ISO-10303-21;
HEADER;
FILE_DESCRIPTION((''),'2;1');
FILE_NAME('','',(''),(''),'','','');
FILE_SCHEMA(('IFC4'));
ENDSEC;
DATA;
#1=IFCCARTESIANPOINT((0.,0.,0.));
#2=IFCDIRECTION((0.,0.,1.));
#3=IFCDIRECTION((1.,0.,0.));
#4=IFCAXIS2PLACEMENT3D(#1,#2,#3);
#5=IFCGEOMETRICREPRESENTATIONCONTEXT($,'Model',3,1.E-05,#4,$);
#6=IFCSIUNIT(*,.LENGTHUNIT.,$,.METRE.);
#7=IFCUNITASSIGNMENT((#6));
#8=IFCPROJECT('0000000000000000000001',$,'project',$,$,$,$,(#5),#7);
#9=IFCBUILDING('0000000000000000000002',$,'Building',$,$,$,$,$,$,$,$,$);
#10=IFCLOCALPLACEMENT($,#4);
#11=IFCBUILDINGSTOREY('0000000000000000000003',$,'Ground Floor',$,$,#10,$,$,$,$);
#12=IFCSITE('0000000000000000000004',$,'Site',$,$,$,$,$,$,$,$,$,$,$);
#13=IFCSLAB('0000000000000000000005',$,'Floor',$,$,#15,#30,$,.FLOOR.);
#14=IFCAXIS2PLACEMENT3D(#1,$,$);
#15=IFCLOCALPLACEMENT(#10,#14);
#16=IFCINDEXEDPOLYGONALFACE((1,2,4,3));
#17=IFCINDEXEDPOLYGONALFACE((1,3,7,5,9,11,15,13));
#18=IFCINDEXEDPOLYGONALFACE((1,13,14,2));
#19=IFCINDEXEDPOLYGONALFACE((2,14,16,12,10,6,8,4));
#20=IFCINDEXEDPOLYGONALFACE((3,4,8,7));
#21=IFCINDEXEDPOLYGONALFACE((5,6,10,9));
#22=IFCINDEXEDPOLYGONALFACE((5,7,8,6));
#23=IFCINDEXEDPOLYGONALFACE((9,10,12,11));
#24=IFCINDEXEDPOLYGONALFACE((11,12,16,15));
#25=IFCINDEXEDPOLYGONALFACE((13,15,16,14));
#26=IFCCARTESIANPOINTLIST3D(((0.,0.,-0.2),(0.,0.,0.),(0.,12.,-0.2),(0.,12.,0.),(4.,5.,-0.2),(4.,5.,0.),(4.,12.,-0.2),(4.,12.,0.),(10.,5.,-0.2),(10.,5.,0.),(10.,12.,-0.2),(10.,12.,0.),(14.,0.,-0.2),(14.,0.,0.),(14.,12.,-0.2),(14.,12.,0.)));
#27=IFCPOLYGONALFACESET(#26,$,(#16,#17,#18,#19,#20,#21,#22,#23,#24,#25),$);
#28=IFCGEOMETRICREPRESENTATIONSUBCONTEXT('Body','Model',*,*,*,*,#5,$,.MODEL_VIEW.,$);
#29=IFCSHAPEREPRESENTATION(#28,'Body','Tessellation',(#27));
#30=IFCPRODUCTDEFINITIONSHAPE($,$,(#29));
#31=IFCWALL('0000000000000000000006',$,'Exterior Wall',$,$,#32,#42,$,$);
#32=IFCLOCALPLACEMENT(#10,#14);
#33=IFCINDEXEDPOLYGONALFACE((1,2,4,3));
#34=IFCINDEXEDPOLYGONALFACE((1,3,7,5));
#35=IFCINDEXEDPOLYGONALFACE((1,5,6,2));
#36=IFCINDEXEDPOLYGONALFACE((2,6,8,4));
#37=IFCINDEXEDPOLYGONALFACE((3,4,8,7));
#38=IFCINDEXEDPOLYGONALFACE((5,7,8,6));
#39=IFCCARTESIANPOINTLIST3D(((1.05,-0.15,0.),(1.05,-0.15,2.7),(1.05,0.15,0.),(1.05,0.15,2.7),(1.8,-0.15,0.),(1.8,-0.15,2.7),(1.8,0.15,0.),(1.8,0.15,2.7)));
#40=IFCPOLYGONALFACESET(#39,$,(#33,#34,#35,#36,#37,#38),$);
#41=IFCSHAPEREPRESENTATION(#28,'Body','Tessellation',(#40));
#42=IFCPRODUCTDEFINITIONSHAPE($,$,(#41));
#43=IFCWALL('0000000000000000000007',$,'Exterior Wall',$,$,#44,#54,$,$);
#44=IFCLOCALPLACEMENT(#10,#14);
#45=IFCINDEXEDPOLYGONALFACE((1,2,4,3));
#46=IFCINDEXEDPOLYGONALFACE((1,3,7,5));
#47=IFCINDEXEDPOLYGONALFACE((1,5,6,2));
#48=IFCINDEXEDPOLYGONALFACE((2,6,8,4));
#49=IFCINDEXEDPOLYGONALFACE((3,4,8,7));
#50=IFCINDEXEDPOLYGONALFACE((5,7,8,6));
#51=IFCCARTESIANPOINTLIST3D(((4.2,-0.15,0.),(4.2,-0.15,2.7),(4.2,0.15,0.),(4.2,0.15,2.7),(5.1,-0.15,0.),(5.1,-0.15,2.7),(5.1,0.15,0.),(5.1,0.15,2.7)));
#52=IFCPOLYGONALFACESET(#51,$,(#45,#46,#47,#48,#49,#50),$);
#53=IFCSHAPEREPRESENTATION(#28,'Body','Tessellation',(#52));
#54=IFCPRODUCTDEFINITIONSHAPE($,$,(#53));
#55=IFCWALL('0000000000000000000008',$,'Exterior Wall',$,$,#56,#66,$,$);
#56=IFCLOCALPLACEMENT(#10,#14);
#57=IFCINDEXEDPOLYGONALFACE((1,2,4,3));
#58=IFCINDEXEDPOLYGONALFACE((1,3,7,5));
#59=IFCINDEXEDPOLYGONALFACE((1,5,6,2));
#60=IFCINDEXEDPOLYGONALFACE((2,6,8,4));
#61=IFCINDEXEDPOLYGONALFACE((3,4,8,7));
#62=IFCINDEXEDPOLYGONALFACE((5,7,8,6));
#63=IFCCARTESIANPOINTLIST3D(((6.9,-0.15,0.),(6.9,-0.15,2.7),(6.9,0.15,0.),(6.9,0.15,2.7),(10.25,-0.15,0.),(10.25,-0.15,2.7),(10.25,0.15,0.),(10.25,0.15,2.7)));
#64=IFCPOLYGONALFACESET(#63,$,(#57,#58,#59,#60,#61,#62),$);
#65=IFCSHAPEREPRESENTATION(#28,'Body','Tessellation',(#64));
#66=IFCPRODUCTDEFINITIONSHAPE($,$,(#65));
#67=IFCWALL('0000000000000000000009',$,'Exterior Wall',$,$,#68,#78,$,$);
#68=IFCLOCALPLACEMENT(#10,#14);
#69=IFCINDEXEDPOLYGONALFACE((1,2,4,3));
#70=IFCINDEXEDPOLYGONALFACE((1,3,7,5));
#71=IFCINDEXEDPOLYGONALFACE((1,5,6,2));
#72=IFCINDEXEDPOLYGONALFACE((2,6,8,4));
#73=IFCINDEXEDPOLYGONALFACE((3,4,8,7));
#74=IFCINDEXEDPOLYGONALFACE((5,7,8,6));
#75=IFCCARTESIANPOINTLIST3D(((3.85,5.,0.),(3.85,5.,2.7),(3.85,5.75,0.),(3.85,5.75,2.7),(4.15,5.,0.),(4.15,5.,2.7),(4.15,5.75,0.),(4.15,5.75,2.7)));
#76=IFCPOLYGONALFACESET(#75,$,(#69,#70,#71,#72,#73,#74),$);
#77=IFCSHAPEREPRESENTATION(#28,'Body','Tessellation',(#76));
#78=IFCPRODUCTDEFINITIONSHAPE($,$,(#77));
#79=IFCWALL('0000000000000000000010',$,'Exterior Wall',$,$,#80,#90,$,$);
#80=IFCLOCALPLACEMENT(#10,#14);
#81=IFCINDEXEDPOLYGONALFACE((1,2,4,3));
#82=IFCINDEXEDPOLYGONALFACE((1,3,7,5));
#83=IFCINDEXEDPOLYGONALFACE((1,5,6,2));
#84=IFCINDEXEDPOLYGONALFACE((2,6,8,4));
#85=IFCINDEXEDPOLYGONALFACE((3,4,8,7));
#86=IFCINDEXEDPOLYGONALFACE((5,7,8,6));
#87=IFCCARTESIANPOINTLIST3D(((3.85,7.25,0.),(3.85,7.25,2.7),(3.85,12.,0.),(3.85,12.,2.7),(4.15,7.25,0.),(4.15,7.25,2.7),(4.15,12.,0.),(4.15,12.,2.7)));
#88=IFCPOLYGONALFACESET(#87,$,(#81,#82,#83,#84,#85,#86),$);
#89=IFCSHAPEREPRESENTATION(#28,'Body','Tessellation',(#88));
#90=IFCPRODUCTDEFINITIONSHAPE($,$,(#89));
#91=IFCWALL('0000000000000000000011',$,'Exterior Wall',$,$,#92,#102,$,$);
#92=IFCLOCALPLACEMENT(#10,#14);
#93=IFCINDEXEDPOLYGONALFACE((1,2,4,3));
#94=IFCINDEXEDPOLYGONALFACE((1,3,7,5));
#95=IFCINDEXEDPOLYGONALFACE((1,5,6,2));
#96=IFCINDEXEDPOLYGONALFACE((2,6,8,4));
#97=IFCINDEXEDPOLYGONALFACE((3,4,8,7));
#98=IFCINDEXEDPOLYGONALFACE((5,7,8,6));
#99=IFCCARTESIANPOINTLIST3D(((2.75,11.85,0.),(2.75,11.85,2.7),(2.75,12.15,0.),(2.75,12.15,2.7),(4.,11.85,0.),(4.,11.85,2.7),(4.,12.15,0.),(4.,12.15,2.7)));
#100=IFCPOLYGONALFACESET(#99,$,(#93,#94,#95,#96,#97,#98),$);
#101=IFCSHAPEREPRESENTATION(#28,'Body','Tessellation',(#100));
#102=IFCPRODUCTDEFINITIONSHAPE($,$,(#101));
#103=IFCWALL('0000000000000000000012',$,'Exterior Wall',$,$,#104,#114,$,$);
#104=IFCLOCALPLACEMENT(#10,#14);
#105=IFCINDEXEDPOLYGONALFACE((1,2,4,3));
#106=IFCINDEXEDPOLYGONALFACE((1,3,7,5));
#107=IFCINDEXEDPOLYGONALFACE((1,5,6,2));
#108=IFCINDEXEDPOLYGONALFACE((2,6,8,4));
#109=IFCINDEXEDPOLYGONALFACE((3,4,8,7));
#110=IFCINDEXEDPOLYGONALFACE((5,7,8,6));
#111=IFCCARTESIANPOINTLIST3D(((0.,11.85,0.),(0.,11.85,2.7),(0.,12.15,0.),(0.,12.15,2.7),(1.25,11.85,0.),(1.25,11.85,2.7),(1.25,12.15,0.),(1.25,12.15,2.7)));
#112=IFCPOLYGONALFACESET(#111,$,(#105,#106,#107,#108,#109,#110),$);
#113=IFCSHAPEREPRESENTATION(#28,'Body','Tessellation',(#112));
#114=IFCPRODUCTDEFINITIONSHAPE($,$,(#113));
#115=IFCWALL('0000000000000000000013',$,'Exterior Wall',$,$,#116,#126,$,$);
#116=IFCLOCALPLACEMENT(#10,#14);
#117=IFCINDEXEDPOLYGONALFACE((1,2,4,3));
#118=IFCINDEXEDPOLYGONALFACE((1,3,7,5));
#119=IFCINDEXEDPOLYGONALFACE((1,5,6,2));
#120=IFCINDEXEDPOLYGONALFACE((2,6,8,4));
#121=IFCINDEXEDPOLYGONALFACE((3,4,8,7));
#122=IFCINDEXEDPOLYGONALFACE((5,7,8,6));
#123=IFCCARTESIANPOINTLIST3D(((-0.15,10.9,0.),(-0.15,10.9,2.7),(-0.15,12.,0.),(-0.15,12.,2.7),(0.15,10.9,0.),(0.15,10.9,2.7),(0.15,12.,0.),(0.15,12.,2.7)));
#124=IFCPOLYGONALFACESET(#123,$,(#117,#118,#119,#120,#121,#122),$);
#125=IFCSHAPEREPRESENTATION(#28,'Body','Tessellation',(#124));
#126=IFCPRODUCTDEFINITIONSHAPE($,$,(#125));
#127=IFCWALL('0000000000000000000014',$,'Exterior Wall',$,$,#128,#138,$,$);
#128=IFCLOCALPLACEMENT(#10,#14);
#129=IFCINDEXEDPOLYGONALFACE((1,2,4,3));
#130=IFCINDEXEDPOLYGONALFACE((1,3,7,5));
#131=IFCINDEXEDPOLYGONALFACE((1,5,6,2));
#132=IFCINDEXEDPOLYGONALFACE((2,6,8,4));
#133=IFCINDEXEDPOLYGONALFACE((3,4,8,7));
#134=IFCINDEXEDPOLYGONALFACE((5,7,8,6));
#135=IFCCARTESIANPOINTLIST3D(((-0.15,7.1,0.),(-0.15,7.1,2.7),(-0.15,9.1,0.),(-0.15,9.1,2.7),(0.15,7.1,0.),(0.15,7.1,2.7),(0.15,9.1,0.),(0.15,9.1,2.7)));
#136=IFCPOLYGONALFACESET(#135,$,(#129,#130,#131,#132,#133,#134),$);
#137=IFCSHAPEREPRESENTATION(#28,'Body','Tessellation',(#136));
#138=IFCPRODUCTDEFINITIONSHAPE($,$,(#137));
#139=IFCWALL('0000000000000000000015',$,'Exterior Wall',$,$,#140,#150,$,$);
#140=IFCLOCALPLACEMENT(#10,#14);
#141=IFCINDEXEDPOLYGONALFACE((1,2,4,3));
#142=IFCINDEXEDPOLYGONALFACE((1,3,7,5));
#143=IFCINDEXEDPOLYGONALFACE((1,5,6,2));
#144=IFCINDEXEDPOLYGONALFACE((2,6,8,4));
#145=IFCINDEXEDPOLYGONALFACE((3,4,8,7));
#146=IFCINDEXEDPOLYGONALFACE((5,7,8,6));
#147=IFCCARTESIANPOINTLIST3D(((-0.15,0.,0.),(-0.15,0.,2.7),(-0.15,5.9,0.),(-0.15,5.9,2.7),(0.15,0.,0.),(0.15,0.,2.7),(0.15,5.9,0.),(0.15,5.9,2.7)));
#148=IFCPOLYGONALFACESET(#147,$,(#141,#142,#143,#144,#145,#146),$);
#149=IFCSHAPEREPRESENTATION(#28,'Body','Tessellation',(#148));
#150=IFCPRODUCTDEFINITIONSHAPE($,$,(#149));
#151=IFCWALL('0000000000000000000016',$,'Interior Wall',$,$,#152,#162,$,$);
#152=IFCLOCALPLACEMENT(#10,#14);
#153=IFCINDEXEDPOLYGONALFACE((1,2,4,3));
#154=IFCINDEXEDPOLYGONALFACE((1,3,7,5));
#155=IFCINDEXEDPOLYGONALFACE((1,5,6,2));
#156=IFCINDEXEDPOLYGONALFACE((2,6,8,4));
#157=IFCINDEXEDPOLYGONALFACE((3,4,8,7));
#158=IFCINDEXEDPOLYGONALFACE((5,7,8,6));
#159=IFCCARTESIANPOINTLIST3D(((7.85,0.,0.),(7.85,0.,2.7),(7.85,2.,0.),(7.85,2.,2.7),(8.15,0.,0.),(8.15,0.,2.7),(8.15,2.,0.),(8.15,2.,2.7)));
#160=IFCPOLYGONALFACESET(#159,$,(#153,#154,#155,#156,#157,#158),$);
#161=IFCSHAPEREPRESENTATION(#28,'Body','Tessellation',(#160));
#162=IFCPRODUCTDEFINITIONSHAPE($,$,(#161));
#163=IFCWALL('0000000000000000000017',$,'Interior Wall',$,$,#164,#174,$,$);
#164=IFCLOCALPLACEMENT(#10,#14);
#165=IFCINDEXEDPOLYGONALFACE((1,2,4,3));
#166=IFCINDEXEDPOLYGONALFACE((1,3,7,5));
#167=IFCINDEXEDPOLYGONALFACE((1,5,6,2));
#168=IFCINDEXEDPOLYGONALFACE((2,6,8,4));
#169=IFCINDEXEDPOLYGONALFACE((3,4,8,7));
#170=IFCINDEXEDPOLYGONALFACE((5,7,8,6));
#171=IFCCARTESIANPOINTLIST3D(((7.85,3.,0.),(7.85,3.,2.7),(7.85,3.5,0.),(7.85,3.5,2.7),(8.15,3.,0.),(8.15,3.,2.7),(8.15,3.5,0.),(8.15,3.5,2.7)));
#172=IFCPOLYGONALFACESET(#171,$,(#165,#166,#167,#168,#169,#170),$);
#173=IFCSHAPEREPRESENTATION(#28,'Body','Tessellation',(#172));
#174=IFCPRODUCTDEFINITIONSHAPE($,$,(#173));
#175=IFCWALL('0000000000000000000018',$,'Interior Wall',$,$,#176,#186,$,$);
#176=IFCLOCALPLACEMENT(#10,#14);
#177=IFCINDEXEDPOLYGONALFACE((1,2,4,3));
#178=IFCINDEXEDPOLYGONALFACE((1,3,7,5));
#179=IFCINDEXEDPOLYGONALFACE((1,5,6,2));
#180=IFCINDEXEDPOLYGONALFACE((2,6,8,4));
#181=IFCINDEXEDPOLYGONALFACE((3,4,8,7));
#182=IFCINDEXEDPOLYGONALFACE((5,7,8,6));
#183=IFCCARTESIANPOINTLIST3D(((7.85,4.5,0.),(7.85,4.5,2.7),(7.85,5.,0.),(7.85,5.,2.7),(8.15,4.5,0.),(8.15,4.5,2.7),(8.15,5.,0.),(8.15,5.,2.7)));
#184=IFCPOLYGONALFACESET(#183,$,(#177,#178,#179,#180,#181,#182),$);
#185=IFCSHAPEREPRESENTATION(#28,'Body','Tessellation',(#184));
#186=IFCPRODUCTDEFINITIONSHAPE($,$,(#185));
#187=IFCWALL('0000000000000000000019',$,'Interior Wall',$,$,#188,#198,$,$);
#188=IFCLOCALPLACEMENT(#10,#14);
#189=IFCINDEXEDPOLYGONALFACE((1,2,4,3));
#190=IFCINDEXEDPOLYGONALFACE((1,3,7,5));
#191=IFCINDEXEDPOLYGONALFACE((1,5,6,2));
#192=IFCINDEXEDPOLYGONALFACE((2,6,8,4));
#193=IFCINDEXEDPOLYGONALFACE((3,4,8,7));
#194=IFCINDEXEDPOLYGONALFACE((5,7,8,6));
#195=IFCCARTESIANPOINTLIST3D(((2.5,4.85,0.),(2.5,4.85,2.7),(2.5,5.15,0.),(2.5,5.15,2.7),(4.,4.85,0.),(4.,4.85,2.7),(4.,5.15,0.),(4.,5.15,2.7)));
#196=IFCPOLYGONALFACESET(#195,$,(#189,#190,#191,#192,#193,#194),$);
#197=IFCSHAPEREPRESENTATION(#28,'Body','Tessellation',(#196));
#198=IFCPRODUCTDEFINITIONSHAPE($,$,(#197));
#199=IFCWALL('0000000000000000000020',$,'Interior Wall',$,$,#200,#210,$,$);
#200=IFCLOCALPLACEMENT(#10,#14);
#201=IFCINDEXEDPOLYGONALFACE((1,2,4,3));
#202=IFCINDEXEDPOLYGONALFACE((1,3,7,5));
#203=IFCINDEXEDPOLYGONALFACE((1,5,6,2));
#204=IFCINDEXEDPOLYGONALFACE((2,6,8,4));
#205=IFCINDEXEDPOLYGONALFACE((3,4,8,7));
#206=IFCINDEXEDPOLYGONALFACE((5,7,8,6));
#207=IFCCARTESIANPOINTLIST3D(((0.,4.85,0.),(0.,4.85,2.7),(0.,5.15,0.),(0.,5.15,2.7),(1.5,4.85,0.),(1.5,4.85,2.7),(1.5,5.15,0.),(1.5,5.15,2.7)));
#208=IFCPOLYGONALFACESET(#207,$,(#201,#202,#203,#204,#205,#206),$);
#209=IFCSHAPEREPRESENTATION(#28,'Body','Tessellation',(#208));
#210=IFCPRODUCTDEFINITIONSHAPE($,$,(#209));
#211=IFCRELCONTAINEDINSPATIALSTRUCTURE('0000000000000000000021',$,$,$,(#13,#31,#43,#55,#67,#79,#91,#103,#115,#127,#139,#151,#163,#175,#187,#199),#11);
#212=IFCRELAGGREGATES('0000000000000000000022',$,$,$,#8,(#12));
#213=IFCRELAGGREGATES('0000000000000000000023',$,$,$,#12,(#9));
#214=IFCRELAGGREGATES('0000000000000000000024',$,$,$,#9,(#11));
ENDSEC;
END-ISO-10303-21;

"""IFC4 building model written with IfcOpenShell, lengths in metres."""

from ifc_helpers import new_model, si_unit, frame, origin_with_axes, place, context, subcontext, project, spatial, indexed_curve, outline, extrude, element, save


model = new_model("IFC4")

# Units and contexts
model_context = context("Model", 3, precision=1e-05, world=origin_with_axes())
body_context = subcontext(model_context, "Body", "Model", "MODEL_VIEW")
ifc_project = project(units=[si_unit("LENGTHUNIT", "METRE")], contexts=[model_context])

# Site, building, storey
site = spatial("IfcSite", under=ifc_project, Name="Site")
building = spatial("IfcBuilding", under=site, Name="Building")
storey_placement = place(None, origin_with_axes())
storey = spatial("IfcBuildingStorey", under=building, at=storey_placement, Name="Ground Floor")

# Slab
slab_placement = place(storey_placement, frame((0.0, 0.0, -0.2), z_axis=(0.0, 0.0, 1.0), x_axis=(1.0, 0.0, 0.0)))
element("IfcSlab", 1, at=slab_placement, inside=storey, Name="Floor", PredefinedType="FLOOR", context=body_context, shape_type="SweptSolid", body=[
    extrude(outline(indexed_curve([(0.0, 0.0), (14.0, 0.0), (14.0, 12.0), (10.0, 12.0), (10.0, 5.0), (4.0, 5.0), (4.0, 12.0), (0.0, 12.0)])), None, (0.0, 0.0, 1.0), 0.2),
])

# Walls
wall_1_placement = place(storey_placement, frame((1.05, 0.0, 0.0), z_axis=(0.0, 0.0, 1.0), x_axis=(1.0, 0.0, 0.0)))
element("IfcWall", 2, at=wall_1_placement, inside=storey, Name="Exterior Wall", context=body_context, shape_type="SweptSolid", body=[
    extrude(outline(indexed_curve([(0.0, 0.0), (0.0, 0.3), (0.75, 0.3), (0.75, 0.0), (0.0, 0.0)], self_intersect=False)), frame((0.0, -0.15, 0.0), z_axis=(0.0, 0.0, 1.0), x_axis=(1.0, 0.0, 0.0)), (0.0, 0.0, 1.0), 2.7),
])
wall_2_placement = place(storey_placement, frame((4.2, 0.0, 0.0), z_axis=(0.0, 0.0, 1.0), x_axis=(1.0, 0.0, 0.0)))
element("IfcWall", 3, at=wall_2_placement, inside=storey, Name="Exterior Wall", context=body_context, shape_type="SweptSolid", body=[
    extrude(outline(indexed_curve([(0.0, 0.0), (0.0, 0.3), (0.9, 0.3), (0.9, 0.0), (0.0, 0.0)], self_intersect=False)), frame((0.0, -0.15, 0.0), z_axis=(0.0, 0.0, 1.0), x_axis=(1.0, 0.0, 0.0)), (0.0, 0.0, 1.0), 2.7),
])
wall_3_placement = place(storey_placement, frame((6.9, 0.0, 0.0), z_axis=(0.0, 0.0, 1.0), x_axis=(1.0, 0.0, 0.0)))
element("IfcWall", 4, at=wall_3_placement, inside=storey, Name="Exterior Wall", context=body_context, shape_type="SweptSolid", body=[
    extrude(outline(indexed_curve([(0.0, 0.0), (0.0, 0.3), (3.35, 0.3), (3.35, 0.0), (0.0, 0.0)], self_intersect=False)), frame((0.0, -0.15, 0.0), z_axis=(0.0, 0.0, 1.0), x_axis=(1.0, 0.0, 0.0)), (0.0, 0.0, 1.0), 2.7),
])
wall_4_placement = place(storey_placement, frame((4.0, 5.0, 0.0), z_axis=(0.0, 0.0, 1.0), x_axis=(0.0, 1.0, 0.0)))
element("IfcWall", 5, at=wall_4_placement, inside=storey, Name="Exterior Wall", context=body_context, shape_type="SweptSolid", body=[
    extrude(outline(indexed_curve([(0.0, 0.0), (0.0, 0.3), (0.75, 0.3), (0.75, 0.0), (0.0, 0.0)], self_intersect=False)), frame((0.0, -0.15, 0.0), z_axis=(0.0, 0.0, 1.0), x_axis=(1.0, 0.0, 0.0)), (0.0, 0.0, 1.0), 2.7),
])
wall_5_placement = place(storey_placement, frame((4.0, 7.25, 0.0), z_axis=(0.0, 0.0, 1.0), x_axis=(0.0, 1.0, 0.0)))
element("IfcWall", 6, at=wall_5_placement, inside=storey, Name="Exterior Wall", context=body_context, shape_type="SweptSolid", body=[
    extrude(outline(indexed_curve([(0.0, 0.0), (0.0, 0.3), (4.75, 0.3), (4.75, 0.0), (0.0, 0.0)], self_intersect=False)), frame((0.0, -0.15, 0.0), z_axis=(0.0, 0.0, 1.0), x_axis=(1.0, 0.0, 0.0)), (0.0, 0.0, 1.0), 2.7),
])
for number, where, z_axis, x_axis, name in (
    (7, (4.0, 12.0, 0.0), (0.0, 0.0, 1.0), (-1.0, 0.0, 0.0), "Exterior Wall"),
    (8, (1.25, 12.0, 0.0), (0.0, 0.0, 1.0), (-1.0, 0.0, 0.0), "Exterior Wall"),
):
    element("IfcWall", number, at=place(storey_placement, frame(where, z_axis=z_axis, x_axis=x_axis)), inside=storey, Name=name, context=body_context, shape_type="SweptSolid", body=[
        extrude(outline(indexed_curve([(0.0, 0.0), (0.0, 0.3), (1.25, 0.3), (1.25, 0.0), (0.0, 0.0)], self_intersect=False)), frame((0.0, -0.15, 0.0), z_axis=(0.0, 0.0, 1.0), x_axis=(1.0, 0.0, 0.0)), (0.0, 0.0, 1.0), 2.7),
    ])
wall_6_placement = place(storey_placement, frame((0.0, 12.0, 0.0), z_axis=(0.0, 0.0, 1.0), x_axis=(0.0, -1.0, 0.0)))
element("IfcWall", 9, at=wall_6_placement, inside=storey, Name="Exterior Wall", context=body_context, shape_type="SweptSolid", body=[
    extrude(outline(indexed_curve([(0.0, 0.0), (0.0, 0.3), (1.1, 0.3), (1.1, 0.0), (0.0, 0.0)], self_intersect=False)), frame((0.0, -0.15, 0.0), z_axis=(0.0, 0.0, 1.0), x_axis=(1.0, 0.0, 0.0)), (0.0, 0.0, 1.0), 2.7),
])
wall_7_placement = place(storey_placement, frame((0.0, 9.1, 0.0), z_axis=(0.0, 0.0, 1.0), x_axis=(0.0, -1.0, 0.0)))
element("IfcWall", 10, at=wall_7_placement, inside=storey, Name="Exterior Wall", context=body_context, shape_type="SweptSolid", body=[
    extrude(outline(indexed_curve([(0.0, 0.0), (0.0, 0.3), (2.0, 0.3), (2.0, 0.0), (0.0, 0.0)], self_intersect=False)), frame((0.0, -0.15, 0.0), z_axis=(0.0, 0.0, 1.0), x_axis=(1.0, 0.0, 0.0)), (0.0, 0.0, 1.0), 2.7),
])
wall_8_placement = place(storey_placement, frame((0.0, 5.9, 0.0), z_axis=(0.0, 0.0, 1.0), x_axis=(0.0, -1.0, 0.0)))
element("IfcWall", 11, at=wall_8_placement, inside=storey, Name="Exterior Wall", context=body_context, shape_type="SweptSolid", body=[
    extrude(outline(indexed_curve([(0.0, 0.0), (0.0, 0.3), (5.9, 0.3), (5.9, 0.0), (0.0, 0.0)], self_intersect=False)), frame((0.0, -0.15, 0.0), z_axis=(0.0, 0.0, 1.0), x_axis=(1.0, 0.0, 0.0)), (0.0, 0.0, 1.0), 2.7),
])
wall_9_placement = place(storey_placement, frame((8.0, 0.0, 0.0), z_axis=(0.0, 0.0, 1.0), x_axis=(0.0, 1.0, 0.0)))
element("IfcWall", 12, at=wall_9_placement, inside=storey, Name="Interior Wall", context=body_context, shape_type="SweptSolid", body=[
    extrude(outline(indexed_curve([(0.0, 0.0), (0.0, 0.3), (2.0, 0.3), (2.0, 0.0), (0.0, 0.0)], self_intersect=False)), frame((0.0, -0.15, 0.0), z_axis=(0.0, 0.0, 1.0), x_axis=(1.0, 0.0, 0.0)), (0.0, 0.0, 1.0), 2.7),
])
for number, where, z_axis, x_axis, name in (
    (13, (8.0, 3.0, 0.0), (0.0, 0.0, 1.0), (0.0, 1.0, 0.0), "Interior Wall"),
    (14, (8.0, 4.5, 0.0), (0.0, 0.0, 1.0), (0.0, 1.0, 0.0), "Interior Wall"),
):
    element("IfcWall", number, at=place(storey_placement, frame(where, z_axis=z_axis, x_axis=x_axis)), inside=storey, Name=name, context=body_context, shape_type="SweptSolid", body=[
        extrude(outline(indexed_curve([(0.0, 0.0), (0.0, 0.3), (0.5, 0.3), (0.5, 0.0), (0.0, 0.0)], self_intersect=False)), frame((0.0, -0.15, 0.0), z_axis=(0.0, 0.0, 1.0), x_axis=(1.0, 0.0, 0.0)), (0.0, 0.0, 1.0), 2.7),
    ])
for number, where, z_axis, x_axis, name in (
    (15, (4.0, 5.0, 0.0), (0.0, 0.0, 1.0), (-1.0, 0.0, 0.0), "Interior Wall"),
    (16, (1.5, 5.0, 0.0), (0.0, 0.0, 1.0), (-1.0, 0.0, 0.0), "Interior Wall"),
):
    element("IfcWall", number, at=place(storey_placement, frame(where, z_axis=z_axis, x_axis=x_axis)), inside=storey, Name=name, context=body_context, shape_type="SweptSolid", body=[
        extrude(outline(indexed_curve([(0.0, 0.0), (0.0, 0.3), (1.5, 0.3), (1.5, 0.0), (0.0, 0.0)], self_intersect=False)), frame((0.0, -0.15, 0.0), z_axis=(0.0, 0.0, 1.0), x_axis=(1.0, 0.0, 0.0)), (0.0, 0.0, 1.0), 2.7),
    ])

save(model, "model.ifc")
